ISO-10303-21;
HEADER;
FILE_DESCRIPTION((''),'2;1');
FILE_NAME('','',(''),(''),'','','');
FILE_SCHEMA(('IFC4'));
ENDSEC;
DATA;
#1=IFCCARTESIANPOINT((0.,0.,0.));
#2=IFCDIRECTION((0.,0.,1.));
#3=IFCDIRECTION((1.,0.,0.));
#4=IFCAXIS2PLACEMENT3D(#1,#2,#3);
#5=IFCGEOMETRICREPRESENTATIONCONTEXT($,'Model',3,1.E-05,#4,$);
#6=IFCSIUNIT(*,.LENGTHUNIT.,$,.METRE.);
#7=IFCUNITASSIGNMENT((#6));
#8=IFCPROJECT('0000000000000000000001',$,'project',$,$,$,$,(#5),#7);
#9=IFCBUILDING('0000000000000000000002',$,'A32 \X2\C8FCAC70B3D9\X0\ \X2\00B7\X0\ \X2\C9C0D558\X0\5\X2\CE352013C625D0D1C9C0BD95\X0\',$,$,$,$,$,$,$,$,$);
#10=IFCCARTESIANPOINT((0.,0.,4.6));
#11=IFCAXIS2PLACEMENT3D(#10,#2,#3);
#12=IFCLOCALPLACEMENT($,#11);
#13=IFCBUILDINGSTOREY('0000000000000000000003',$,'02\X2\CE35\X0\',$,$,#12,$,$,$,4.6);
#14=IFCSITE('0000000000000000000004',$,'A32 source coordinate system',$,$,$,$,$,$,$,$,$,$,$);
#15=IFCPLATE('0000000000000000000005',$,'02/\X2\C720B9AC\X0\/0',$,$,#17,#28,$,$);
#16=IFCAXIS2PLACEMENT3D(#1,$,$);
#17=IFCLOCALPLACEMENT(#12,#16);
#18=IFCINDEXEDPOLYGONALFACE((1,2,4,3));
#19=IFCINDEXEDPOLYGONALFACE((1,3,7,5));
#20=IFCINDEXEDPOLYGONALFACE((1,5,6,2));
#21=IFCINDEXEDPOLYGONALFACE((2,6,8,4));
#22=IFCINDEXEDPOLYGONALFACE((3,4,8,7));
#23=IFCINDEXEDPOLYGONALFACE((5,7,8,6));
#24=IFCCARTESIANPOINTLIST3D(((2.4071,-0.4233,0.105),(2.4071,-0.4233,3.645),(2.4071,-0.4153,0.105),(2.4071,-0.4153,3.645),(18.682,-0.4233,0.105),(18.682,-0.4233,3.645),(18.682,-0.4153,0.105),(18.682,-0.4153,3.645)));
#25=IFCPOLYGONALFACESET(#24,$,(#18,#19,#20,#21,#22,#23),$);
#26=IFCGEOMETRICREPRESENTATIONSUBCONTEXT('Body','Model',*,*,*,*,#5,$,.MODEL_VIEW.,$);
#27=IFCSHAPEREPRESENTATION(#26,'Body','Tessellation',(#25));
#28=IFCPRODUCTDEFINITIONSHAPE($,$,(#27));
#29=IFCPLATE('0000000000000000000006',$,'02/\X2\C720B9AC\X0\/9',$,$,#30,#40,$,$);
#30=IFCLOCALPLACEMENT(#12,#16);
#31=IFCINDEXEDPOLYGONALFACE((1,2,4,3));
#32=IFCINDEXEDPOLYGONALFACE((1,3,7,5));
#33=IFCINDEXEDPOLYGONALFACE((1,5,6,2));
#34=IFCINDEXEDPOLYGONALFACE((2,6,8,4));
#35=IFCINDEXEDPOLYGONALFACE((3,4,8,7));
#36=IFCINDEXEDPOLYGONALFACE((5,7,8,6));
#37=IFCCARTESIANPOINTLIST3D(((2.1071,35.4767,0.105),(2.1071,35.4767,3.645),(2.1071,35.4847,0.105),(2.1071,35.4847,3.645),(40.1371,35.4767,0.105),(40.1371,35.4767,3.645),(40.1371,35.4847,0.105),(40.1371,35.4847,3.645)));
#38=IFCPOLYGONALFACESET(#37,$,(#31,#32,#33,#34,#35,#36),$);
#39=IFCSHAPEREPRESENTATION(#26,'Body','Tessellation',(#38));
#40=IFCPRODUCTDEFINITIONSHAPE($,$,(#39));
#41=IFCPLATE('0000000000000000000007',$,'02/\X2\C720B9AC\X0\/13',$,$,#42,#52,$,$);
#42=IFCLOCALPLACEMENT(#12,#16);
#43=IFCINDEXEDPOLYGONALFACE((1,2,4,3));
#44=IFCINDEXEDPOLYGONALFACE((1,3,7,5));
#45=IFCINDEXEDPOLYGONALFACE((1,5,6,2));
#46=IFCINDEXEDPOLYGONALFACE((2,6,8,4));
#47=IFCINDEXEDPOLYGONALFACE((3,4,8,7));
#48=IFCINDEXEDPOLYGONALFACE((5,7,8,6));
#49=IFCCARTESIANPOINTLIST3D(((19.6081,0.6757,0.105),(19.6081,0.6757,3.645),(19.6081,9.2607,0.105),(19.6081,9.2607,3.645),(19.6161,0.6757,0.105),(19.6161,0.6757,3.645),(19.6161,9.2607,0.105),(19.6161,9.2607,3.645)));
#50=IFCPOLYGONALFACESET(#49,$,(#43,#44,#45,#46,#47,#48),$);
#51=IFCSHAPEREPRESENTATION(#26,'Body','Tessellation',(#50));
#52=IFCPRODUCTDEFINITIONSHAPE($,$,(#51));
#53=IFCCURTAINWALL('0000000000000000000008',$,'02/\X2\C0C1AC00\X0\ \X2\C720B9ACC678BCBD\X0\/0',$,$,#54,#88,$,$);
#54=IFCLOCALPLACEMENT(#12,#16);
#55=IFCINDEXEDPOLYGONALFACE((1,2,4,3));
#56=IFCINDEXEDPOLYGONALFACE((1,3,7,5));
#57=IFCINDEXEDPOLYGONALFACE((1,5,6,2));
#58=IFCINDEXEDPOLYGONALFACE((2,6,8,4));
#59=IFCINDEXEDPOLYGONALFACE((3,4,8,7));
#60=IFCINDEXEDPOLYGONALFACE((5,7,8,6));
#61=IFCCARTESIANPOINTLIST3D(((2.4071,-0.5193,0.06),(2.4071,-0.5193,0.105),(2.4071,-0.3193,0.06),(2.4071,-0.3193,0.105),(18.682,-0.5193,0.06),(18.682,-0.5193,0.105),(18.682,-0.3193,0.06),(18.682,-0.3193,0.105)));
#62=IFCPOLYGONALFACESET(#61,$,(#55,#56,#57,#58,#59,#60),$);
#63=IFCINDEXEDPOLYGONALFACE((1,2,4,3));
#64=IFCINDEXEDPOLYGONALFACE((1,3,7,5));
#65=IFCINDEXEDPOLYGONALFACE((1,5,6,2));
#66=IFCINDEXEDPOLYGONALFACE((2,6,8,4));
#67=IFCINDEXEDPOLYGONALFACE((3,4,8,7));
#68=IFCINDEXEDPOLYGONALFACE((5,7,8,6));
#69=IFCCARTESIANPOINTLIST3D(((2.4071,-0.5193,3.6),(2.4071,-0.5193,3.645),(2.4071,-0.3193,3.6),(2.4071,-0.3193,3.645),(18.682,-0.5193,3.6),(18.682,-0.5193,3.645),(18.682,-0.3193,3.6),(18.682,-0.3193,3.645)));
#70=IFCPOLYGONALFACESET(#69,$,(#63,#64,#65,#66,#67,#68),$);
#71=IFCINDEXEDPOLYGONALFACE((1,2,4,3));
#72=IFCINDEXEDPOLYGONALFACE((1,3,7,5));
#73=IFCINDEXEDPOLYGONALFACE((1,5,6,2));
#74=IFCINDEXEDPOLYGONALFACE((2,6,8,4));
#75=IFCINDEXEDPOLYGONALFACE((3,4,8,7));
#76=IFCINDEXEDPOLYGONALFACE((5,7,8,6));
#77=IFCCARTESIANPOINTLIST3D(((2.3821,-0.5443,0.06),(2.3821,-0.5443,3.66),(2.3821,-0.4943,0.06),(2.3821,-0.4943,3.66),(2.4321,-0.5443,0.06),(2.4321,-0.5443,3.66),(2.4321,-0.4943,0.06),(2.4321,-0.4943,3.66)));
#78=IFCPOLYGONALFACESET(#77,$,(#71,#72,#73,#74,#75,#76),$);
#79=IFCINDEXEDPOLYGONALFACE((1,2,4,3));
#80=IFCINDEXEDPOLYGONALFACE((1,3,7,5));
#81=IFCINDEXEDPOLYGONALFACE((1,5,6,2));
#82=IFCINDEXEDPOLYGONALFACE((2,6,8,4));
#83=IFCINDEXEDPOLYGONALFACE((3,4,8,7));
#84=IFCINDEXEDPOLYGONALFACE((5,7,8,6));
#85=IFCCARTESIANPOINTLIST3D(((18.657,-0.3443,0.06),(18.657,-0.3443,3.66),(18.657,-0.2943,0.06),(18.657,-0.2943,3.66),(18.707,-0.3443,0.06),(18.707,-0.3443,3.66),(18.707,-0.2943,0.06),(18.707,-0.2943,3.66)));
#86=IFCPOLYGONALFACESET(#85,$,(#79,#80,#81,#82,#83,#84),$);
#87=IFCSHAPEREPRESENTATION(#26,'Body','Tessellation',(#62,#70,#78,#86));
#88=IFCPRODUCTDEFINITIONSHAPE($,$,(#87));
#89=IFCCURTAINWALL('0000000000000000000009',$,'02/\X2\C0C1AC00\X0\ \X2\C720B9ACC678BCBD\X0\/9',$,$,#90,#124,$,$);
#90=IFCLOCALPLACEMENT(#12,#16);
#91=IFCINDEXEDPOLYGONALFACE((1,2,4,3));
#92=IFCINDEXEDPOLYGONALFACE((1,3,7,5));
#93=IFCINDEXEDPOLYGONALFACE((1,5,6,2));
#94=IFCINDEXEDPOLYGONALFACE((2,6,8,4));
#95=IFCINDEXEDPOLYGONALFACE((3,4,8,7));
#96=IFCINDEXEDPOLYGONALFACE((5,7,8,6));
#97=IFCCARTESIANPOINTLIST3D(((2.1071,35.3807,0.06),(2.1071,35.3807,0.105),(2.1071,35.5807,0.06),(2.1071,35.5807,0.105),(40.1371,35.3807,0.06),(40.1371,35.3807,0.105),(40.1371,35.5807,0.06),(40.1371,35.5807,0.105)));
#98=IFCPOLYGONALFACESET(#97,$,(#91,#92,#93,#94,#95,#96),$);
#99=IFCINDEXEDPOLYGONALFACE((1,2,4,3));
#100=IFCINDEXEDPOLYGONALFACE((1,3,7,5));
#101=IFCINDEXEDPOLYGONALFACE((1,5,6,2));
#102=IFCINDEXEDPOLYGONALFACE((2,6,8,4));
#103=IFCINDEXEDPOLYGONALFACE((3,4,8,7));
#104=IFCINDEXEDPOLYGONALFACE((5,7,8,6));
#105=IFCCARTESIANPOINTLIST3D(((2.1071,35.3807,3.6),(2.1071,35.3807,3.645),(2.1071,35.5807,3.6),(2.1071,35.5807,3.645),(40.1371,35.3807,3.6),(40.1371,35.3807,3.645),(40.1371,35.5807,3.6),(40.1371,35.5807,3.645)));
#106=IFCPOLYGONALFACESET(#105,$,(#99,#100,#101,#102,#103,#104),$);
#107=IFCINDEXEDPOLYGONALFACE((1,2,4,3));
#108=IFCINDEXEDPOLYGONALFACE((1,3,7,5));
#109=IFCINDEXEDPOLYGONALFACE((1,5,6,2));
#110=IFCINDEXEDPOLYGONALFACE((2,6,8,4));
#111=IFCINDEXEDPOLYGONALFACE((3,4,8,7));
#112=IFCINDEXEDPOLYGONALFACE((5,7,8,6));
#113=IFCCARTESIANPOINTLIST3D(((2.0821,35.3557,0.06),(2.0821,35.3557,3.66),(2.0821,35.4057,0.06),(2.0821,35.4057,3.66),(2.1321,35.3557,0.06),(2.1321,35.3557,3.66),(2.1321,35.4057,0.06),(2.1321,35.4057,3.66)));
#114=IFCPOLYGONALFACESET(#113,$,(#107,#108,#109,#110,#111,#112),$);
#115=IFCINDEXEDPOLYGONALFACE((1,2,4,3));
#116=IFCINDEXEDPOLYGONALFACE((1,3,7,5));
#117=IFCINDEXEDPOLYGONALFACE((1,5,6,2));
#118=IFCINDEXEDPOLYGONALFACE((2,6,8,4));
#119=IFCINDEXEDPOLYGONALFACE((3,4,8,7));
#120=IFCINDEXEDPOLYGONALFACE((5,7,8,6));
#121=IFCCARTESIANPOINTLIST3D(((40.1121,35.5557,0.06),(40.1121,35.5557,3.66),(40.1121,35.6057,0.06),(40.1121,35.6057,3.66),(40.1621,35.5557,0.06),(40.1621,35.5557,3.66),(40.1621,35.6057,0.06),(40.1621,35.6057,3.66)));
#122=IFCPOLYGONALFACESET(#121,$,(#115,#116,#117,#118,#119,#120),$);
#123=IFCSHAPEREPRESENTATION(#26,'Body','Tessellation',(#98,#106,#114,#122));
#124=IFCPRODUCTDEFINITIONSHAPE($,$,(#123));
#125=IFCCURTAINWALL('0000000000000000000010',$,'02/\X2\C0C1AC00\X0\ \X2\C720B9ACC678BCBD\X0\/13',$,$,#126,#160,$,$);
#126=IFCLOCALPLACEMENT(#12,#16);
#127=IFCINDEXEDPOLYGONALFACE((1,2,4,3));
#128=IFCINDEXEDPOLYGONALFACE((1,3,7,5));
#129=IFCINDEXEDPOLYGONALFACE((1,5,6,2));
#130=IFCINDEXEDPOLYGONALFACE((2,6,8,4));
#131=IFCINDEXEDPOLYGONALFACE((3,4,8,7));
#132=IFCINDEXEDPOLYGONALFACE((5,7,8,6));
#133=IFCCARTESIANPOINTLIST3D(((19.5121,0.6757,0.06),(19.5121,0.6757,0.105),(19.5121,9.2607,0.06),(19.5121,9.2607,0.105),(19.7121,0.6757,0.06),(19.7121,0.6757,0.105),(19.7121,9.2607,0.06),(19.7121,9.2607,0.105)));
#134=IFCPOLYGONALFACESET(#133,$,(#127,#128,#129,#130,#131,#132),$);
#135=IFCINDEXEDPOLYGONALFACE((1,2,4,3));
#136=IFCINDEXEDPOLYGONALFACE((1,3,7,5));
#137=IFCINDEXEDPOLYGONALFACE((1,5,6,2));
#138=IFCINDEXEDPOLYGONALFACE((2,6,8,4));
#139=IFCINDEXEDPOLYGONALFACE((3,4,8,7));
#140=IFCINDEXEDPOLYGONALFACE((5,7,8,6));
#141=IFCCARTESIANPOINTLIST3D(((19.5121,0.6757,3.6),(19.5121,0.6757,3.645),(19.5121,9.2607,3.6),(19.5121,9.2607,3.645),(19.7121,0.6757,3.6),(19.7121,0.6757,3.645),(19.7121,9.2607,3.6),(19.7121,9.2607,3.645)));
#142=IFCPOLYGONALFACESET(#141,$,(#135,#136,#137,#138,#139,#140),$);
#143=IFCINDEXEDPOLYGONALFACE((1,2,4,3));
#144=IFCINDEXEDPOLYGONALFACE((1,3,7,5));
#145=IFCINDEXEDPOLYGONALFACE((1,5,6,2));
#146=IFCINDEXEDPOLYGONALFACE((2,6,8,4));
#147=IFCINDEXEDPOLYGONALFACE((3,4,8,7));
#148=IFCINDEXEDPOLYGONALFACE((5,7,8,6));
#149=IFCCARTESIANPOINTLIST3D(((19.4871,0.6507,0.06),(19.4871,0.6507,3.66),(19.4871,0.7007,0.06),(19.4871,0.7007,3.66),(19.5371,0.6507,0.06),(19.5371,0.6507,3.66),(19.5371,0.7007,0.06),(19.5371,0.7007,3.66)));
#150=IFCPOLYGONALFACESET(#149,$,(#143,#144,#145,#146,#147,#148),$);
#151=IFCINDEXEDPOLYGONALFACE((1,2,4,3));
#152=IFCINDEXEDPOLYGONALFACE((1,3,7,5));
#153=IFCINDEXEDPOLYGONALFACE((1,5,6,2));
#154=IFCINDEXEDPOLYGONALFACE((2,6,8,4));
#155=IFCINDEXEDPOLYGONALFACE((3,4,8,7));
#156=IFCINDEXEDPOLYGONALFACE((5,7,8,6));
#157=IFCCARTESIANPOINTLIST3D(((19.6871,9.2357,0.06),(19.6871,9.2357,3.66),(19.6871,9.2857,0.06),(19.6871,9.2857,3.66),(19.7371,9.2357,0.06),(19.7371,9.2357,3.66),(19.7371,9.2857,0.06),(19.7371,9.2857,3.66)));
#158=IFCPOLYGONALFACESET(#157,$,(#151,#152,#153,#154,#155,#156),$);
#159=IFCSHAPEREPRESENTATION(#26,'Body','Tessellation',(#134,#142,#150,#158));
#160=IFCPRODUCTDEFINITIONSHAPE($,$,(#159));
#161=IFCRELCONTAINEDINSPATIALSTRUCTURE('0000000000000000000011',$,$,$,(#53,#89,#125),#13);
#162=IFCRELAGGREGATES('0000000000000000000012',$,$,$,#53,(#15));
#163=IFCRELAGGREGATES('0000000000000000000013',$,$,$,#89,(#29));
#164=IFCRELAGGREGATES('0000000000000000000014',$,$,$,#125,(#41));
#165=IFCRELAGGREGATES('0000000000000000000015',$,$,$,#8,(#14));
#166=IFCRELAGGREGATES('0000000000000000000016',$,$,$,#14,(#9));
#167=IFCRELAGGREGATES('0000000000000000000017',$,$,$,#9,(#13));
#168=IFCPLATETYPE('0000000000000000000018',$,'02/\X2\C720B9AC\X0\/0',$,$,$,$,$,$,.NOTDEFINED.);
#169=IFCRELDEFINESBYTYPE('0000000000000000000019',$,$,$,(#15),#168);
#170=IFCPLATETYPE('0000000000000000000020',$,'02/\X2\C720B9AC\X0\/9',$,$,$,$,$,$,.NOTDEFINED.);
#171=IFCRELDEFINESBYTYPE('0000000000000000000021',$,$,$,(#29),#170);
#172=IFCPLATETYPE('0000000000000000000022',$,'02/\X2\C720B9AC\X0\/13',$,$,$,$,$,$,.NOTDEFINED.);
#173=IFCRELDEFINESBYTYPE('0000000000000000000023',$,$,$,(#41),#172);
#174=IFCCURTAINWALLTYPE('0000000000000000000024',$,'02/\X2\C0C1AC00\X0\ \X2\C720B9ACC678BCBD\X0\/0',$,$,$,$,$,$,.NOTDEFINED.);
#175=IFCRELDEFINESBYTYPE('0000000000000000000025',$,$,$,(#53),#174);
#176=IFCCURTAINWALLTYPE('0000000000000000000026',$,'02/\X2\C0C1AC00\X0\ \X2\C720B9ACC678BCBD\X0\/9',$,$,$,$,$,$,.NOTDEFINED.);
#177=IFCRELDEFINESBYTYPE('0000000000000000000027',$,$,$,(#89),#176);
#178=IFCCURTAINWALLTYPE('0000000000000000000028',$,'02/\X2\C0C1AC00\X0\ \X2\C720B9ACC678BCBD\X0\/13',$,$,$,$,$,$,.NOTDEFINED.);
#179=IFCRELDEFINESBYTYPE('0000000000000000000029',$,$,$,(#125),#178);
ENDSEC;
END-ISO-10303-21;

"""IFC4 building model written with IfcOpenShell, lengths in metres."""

from ifc_helpers import new_model, si_unit, frame, origin, origin_with_axes, place, context, subcontext, project, spatial, polyline, outline, extrude, source, transform, mapped, type_object, type_shapes, element, aggregate, save


model = new_model("IFC4")

# Units and contexts
model_context = context("Model", 3, precision=1e-05, world=origin_with_axes())
body_context = subcontext(model_context, "Body", "Model", "MODEL_VIEW")
ifc_project = project(units=[si_unit("LENGTHUNIT", "METRE")], contexts=[model_context])

# Plates
plate_type_1 = type_object("IfcPlateType", Name="02/유리/0", PredefinedType="NOTDEFINED")
shared_shape_1 = source(origin(), body_context, "Body", "SweptSolid", [
    extrude(outline(polyline([(18.682, -0.4233), (2.4071, -0.4233), (2.4071, -0.4153), (18.682, -0.4153), (18.682, -0.4233)])), frame((0.0, 0.0, 0.105)), (0.0, 0.0, 1.0), 3.54),
])
type_shapes(plate_type_1, [shared_shape_1])
storey_placement = place(None, frame((0.0, 0.0, 4.6), z_axis=(0.0, 0.0, 1.0), x_axis=(1.0, 0.0, 0.0)))
curtain_wall_1_placement = place(storey_placement, origin_with_axes())
plate_1_placement = place(curtain_wall_1_placement, origin_with_axes())
plate_1 = element("IfcPlate", 1, at=plate_1_placement, type_object=plate_type_1, Name="02/유리/0", context=body_context, shape_type="MappedRepresentation", body=[
    mapped(shared_shape_1, transform((0.0, 0.0, 0.0), scale=1.0)),
])
plate_type_2 = type_object("IfcPlateType", Name="02/유리/9", PredefinedType="NOTDEFINED")
shared_shape_2 = source(origin(), body_context, "Body", "SweptSolid", [
    extrude(outline(polyline([(40.1371, 35.4767), (2.1071, 35.4767), (2.1071, 35.4847), (40.1371, 35.4847), (40.1371, 35.4767)])), frame((0.0, 0.0, 0.105)), (0.0, 0.0, 1.0), 3.54),
])
type_shapes(plate_type_2, [shared_shape_2])
curtain_wall_2_placement = place(storey_placement, origin_with_axes())
plate_2_placement = place(curtain_wall_2_placement, origin_with_axes())
plate_2 = element("IfcPlate", 2, at=plate_2_placement, type_object=plate_type_2, Name="02/유리/9", context=body_context, shape_type="MappedRepresentation", body=[
    mapped(shared_shape_2, transform((0.0, 0.0, 0.0), scale=1.0)),
])
plate_type_3 = type_object("IfcPlateType", Name="02/유리/13", PredefinedType="NOTDEFINED")
shared_shape_3 = source(origin(), body_context, "Body", "SweptSolid", [
    extrude(outline(polyline([(19.6161, 0.6757), (19.6081, 0.6757), (19.6081, 9.2607), (19.6161, 9.2607), (19.6161, 0.6757)])), frame((0.0, 0.0, 0.105)), (0.0, 0.0, 1.0), 3.54),
])
type_shapes(plate_type_3, [shared_shape_3])
curtain_wall_3_placement = place(storey_placement, origin_with_axes())
plate_3_placement = place(curtain_wall_3_placement, origin_with_axes())
plate_3 = element("IfcPlate", 3, at=plate_3_placement, type_object=plate_type_3, Name="02/유리/13", context=body_context, shape_type="MappedRepresentation", body=[
    mapped(shared_shape_3, transform((0.0, 0.0, 0.0), scale=1.0)),
])

# Site, building, storey
site = spatial("IfcSite", under=ifc_project, Name="A32 source coordinate system")
building = spatial("IfcBuilding", under=site, Name="A32 주거동 · 지하5층–옥탑지붕")
storey = spatial("IfcBuildingStorey", under=building, at=storey_placement, Name="02층", Elevation=4.6)

# Curtain walls
curtain_wall_type_1 = type_object("IfcCurtainWallType", Name="02/상가 유리외벽/0", PredefinedType="NOTDEFINED")
shared_shape_4 = source(origin(), body_context, "Body", "SweptSolid", [
    extrude(outline(polyline([(18.682, -0.5193), (2.4071, -0.5193), (2.4071, -0.3193), (18.682, -0.3193), (18.682, -0.5193)])), frame((0.0, 0.0, 0.06)), (0.0, 0.0, 1.0), 0.045),
    extrude(outline(polyline([(18.682, -0.5193), (18.682, -0.3193), (2.4071, -0.3193), (2.4071, -0.5193), (18.682, -0.5193)])), frame((0.0, 0.0, 3.6)), (0.0, 0.0, 1.0), 0.045),
    extrude(outline(polyline([(2.4321, -0.5443), (2.4321, -0.4943), (2.3821, -0.4943), (2.3821, -0.5443), (2.4321, -0.5443)])), frame((0.0, 0.0, 0.06)), (0.0, 0.0, 1.0), 3.6),
    extrude(outline(polyline([(18.707, -0.3443), (18.707, -0.2943), (18.657, -0.2943), (18.657, -0.3443), (18.707, -0.3443)])), frame((0.0, 0.0, 0.06)), (0.0, 0.0, 1.0), 3.6),
])
type_shapes(curtain_wall_type_1, [shared_shape_4])
curtain_wall_1 = element("IfcCurtainWall", 4, at=curtain_wall_1_placement, inside=storey, type_object=curtain_wall_type_1, Name="02/상가 유리외벽/0", context=body_context, shape_type="MappedRepresentation", body=[
    mapped(shared_shape_4, transform((0.0, 0.0, 0.0), scale=1.0)),
])
aggregate(curtain_wall_1, [plate_1])
curtain_wall_type_2 = type_object("IfcCurtainWallType", Name="02/상가 유리외벽/9", PredefinedType="NOTDEFINED")
shared_shape_5 = source(origin(), body_context, "Body", "SweptSolid", [
    extrude(outline(polyline([(40.1371, 35.3807), (2.1071, 35.3807), (2.1071, 35.5807), (40.1371, 35.5807), (40.1371, 35.3807)])), frame((0.0, 0.0, 0.06)), (0.0, 0.0, 1.0), 0.045),
    extrude(outline(polyline([(40.1371, 35.3807), (40.1371, 35.5807), (2.1071, 35.5807), (2.1071, 35.3807), (40.1371, 35.3807)])), frame((0.0, 0.0, 3.6)), (0.0, 0.0, 1.0), 0.045),
    extrude(outline(polyline([(2.1321, 35.3557), (2.1321, 35.4057), (2.0821, 35.4057), (2.0821, 35.3557), (2.1321, 35.3557)])), frame((0.0, 0.0, 0.06)), (0.0, 0.0, 1.0), 3.6),
    extrude(outline(polyline([(40.1621, 35.5557), (40.1621, 35.6057), (40.1121, 35.6057), (40.1121, 35.5557), (40.1621, 35.5557)])), frame((0.0, 0.0, 0.06)), (0.0, 0.0, 1.0), 3.6),
])
type_shapes(curtain_wall_type_2, [shared_shape_5])
curtain_wall_2 = element("IfcCurtainWall", 5, at=curtain_wall_2_placement, inside=storey, type_object=curtain_wall_type_2, Name="02/상가 유리외벽/9", context=body_context, shape_type="MappedRepresentation", body=[
    mapped(shared_shape_5, transform((0.0, 0.0, 0.0), scale=1.0)),
])
aggregate(curtain_wall_2, [plate_2])
curtain_wall_type_3 = type_object("IfcCurtainWallType", Name="02/상가 유리외벽/13", PredefinedType="NOTDEFINED")
shared_shape_6 = source(origin(), body_context, "Body", "SweptSolid", [
    extrude(outline(polyline([(19.7121, 0.6757), (19.5121, 0.6757), (19.5121, 9.2607), (19.7121, 9.2607), (19.7121, 0.6757)])), frame((0.0, 0.0, 0.06)), (0.0, 0.0, 1.0), 0.045),
    extrude(outline(polyline([(19.7121, 0.6757), (19.7121, 9.2607), (19.5121, 9.2607), (19.5121, 0.6757), (19.7121, 0.6757)])), frame((0.0, 0.0, 3.6)), (0.0, 0.0, 1.0), 0.045),
    extrude(outline(polyline([(19.5371, 0.6507), (19.5371, 0.7007), (19.4871, 0.7007), (19.4871, 0.6507), (19.5371, 0.6507)])), frame((0.0, 0.0, 0.06)), (0.0, 0.0, 1.0), 3.6),
    extrude(outline(polyline([(19.7371, 9.2357), (19.7371, 9.2857), (19.6871, 9.2857), (19.6871, 9.2357), (19.7371, 9.2357)])), frame((0.0, 0.0, 0.06)), (0.0, 0.0, 1.0), 3.6),
])
type_shapes(curtain_wall_type_3, [shared_shape_6])
curtain_wall_3 = element("IfcCurtainWall", 6, at=curtain_wall_3_placement, inside=storey, type_object=curtain_wall_type_3, Name="02/상가 유리외벽/13", context=body_context, shape_type="MappedRepresentation", body=[
    mapped(shared_shape_6, transform((0.0, 0.0, 0.0), scale=1.0)),
])
aggregate(curtain_wall_3, [plate_3])

save(model, "model.ifc")
